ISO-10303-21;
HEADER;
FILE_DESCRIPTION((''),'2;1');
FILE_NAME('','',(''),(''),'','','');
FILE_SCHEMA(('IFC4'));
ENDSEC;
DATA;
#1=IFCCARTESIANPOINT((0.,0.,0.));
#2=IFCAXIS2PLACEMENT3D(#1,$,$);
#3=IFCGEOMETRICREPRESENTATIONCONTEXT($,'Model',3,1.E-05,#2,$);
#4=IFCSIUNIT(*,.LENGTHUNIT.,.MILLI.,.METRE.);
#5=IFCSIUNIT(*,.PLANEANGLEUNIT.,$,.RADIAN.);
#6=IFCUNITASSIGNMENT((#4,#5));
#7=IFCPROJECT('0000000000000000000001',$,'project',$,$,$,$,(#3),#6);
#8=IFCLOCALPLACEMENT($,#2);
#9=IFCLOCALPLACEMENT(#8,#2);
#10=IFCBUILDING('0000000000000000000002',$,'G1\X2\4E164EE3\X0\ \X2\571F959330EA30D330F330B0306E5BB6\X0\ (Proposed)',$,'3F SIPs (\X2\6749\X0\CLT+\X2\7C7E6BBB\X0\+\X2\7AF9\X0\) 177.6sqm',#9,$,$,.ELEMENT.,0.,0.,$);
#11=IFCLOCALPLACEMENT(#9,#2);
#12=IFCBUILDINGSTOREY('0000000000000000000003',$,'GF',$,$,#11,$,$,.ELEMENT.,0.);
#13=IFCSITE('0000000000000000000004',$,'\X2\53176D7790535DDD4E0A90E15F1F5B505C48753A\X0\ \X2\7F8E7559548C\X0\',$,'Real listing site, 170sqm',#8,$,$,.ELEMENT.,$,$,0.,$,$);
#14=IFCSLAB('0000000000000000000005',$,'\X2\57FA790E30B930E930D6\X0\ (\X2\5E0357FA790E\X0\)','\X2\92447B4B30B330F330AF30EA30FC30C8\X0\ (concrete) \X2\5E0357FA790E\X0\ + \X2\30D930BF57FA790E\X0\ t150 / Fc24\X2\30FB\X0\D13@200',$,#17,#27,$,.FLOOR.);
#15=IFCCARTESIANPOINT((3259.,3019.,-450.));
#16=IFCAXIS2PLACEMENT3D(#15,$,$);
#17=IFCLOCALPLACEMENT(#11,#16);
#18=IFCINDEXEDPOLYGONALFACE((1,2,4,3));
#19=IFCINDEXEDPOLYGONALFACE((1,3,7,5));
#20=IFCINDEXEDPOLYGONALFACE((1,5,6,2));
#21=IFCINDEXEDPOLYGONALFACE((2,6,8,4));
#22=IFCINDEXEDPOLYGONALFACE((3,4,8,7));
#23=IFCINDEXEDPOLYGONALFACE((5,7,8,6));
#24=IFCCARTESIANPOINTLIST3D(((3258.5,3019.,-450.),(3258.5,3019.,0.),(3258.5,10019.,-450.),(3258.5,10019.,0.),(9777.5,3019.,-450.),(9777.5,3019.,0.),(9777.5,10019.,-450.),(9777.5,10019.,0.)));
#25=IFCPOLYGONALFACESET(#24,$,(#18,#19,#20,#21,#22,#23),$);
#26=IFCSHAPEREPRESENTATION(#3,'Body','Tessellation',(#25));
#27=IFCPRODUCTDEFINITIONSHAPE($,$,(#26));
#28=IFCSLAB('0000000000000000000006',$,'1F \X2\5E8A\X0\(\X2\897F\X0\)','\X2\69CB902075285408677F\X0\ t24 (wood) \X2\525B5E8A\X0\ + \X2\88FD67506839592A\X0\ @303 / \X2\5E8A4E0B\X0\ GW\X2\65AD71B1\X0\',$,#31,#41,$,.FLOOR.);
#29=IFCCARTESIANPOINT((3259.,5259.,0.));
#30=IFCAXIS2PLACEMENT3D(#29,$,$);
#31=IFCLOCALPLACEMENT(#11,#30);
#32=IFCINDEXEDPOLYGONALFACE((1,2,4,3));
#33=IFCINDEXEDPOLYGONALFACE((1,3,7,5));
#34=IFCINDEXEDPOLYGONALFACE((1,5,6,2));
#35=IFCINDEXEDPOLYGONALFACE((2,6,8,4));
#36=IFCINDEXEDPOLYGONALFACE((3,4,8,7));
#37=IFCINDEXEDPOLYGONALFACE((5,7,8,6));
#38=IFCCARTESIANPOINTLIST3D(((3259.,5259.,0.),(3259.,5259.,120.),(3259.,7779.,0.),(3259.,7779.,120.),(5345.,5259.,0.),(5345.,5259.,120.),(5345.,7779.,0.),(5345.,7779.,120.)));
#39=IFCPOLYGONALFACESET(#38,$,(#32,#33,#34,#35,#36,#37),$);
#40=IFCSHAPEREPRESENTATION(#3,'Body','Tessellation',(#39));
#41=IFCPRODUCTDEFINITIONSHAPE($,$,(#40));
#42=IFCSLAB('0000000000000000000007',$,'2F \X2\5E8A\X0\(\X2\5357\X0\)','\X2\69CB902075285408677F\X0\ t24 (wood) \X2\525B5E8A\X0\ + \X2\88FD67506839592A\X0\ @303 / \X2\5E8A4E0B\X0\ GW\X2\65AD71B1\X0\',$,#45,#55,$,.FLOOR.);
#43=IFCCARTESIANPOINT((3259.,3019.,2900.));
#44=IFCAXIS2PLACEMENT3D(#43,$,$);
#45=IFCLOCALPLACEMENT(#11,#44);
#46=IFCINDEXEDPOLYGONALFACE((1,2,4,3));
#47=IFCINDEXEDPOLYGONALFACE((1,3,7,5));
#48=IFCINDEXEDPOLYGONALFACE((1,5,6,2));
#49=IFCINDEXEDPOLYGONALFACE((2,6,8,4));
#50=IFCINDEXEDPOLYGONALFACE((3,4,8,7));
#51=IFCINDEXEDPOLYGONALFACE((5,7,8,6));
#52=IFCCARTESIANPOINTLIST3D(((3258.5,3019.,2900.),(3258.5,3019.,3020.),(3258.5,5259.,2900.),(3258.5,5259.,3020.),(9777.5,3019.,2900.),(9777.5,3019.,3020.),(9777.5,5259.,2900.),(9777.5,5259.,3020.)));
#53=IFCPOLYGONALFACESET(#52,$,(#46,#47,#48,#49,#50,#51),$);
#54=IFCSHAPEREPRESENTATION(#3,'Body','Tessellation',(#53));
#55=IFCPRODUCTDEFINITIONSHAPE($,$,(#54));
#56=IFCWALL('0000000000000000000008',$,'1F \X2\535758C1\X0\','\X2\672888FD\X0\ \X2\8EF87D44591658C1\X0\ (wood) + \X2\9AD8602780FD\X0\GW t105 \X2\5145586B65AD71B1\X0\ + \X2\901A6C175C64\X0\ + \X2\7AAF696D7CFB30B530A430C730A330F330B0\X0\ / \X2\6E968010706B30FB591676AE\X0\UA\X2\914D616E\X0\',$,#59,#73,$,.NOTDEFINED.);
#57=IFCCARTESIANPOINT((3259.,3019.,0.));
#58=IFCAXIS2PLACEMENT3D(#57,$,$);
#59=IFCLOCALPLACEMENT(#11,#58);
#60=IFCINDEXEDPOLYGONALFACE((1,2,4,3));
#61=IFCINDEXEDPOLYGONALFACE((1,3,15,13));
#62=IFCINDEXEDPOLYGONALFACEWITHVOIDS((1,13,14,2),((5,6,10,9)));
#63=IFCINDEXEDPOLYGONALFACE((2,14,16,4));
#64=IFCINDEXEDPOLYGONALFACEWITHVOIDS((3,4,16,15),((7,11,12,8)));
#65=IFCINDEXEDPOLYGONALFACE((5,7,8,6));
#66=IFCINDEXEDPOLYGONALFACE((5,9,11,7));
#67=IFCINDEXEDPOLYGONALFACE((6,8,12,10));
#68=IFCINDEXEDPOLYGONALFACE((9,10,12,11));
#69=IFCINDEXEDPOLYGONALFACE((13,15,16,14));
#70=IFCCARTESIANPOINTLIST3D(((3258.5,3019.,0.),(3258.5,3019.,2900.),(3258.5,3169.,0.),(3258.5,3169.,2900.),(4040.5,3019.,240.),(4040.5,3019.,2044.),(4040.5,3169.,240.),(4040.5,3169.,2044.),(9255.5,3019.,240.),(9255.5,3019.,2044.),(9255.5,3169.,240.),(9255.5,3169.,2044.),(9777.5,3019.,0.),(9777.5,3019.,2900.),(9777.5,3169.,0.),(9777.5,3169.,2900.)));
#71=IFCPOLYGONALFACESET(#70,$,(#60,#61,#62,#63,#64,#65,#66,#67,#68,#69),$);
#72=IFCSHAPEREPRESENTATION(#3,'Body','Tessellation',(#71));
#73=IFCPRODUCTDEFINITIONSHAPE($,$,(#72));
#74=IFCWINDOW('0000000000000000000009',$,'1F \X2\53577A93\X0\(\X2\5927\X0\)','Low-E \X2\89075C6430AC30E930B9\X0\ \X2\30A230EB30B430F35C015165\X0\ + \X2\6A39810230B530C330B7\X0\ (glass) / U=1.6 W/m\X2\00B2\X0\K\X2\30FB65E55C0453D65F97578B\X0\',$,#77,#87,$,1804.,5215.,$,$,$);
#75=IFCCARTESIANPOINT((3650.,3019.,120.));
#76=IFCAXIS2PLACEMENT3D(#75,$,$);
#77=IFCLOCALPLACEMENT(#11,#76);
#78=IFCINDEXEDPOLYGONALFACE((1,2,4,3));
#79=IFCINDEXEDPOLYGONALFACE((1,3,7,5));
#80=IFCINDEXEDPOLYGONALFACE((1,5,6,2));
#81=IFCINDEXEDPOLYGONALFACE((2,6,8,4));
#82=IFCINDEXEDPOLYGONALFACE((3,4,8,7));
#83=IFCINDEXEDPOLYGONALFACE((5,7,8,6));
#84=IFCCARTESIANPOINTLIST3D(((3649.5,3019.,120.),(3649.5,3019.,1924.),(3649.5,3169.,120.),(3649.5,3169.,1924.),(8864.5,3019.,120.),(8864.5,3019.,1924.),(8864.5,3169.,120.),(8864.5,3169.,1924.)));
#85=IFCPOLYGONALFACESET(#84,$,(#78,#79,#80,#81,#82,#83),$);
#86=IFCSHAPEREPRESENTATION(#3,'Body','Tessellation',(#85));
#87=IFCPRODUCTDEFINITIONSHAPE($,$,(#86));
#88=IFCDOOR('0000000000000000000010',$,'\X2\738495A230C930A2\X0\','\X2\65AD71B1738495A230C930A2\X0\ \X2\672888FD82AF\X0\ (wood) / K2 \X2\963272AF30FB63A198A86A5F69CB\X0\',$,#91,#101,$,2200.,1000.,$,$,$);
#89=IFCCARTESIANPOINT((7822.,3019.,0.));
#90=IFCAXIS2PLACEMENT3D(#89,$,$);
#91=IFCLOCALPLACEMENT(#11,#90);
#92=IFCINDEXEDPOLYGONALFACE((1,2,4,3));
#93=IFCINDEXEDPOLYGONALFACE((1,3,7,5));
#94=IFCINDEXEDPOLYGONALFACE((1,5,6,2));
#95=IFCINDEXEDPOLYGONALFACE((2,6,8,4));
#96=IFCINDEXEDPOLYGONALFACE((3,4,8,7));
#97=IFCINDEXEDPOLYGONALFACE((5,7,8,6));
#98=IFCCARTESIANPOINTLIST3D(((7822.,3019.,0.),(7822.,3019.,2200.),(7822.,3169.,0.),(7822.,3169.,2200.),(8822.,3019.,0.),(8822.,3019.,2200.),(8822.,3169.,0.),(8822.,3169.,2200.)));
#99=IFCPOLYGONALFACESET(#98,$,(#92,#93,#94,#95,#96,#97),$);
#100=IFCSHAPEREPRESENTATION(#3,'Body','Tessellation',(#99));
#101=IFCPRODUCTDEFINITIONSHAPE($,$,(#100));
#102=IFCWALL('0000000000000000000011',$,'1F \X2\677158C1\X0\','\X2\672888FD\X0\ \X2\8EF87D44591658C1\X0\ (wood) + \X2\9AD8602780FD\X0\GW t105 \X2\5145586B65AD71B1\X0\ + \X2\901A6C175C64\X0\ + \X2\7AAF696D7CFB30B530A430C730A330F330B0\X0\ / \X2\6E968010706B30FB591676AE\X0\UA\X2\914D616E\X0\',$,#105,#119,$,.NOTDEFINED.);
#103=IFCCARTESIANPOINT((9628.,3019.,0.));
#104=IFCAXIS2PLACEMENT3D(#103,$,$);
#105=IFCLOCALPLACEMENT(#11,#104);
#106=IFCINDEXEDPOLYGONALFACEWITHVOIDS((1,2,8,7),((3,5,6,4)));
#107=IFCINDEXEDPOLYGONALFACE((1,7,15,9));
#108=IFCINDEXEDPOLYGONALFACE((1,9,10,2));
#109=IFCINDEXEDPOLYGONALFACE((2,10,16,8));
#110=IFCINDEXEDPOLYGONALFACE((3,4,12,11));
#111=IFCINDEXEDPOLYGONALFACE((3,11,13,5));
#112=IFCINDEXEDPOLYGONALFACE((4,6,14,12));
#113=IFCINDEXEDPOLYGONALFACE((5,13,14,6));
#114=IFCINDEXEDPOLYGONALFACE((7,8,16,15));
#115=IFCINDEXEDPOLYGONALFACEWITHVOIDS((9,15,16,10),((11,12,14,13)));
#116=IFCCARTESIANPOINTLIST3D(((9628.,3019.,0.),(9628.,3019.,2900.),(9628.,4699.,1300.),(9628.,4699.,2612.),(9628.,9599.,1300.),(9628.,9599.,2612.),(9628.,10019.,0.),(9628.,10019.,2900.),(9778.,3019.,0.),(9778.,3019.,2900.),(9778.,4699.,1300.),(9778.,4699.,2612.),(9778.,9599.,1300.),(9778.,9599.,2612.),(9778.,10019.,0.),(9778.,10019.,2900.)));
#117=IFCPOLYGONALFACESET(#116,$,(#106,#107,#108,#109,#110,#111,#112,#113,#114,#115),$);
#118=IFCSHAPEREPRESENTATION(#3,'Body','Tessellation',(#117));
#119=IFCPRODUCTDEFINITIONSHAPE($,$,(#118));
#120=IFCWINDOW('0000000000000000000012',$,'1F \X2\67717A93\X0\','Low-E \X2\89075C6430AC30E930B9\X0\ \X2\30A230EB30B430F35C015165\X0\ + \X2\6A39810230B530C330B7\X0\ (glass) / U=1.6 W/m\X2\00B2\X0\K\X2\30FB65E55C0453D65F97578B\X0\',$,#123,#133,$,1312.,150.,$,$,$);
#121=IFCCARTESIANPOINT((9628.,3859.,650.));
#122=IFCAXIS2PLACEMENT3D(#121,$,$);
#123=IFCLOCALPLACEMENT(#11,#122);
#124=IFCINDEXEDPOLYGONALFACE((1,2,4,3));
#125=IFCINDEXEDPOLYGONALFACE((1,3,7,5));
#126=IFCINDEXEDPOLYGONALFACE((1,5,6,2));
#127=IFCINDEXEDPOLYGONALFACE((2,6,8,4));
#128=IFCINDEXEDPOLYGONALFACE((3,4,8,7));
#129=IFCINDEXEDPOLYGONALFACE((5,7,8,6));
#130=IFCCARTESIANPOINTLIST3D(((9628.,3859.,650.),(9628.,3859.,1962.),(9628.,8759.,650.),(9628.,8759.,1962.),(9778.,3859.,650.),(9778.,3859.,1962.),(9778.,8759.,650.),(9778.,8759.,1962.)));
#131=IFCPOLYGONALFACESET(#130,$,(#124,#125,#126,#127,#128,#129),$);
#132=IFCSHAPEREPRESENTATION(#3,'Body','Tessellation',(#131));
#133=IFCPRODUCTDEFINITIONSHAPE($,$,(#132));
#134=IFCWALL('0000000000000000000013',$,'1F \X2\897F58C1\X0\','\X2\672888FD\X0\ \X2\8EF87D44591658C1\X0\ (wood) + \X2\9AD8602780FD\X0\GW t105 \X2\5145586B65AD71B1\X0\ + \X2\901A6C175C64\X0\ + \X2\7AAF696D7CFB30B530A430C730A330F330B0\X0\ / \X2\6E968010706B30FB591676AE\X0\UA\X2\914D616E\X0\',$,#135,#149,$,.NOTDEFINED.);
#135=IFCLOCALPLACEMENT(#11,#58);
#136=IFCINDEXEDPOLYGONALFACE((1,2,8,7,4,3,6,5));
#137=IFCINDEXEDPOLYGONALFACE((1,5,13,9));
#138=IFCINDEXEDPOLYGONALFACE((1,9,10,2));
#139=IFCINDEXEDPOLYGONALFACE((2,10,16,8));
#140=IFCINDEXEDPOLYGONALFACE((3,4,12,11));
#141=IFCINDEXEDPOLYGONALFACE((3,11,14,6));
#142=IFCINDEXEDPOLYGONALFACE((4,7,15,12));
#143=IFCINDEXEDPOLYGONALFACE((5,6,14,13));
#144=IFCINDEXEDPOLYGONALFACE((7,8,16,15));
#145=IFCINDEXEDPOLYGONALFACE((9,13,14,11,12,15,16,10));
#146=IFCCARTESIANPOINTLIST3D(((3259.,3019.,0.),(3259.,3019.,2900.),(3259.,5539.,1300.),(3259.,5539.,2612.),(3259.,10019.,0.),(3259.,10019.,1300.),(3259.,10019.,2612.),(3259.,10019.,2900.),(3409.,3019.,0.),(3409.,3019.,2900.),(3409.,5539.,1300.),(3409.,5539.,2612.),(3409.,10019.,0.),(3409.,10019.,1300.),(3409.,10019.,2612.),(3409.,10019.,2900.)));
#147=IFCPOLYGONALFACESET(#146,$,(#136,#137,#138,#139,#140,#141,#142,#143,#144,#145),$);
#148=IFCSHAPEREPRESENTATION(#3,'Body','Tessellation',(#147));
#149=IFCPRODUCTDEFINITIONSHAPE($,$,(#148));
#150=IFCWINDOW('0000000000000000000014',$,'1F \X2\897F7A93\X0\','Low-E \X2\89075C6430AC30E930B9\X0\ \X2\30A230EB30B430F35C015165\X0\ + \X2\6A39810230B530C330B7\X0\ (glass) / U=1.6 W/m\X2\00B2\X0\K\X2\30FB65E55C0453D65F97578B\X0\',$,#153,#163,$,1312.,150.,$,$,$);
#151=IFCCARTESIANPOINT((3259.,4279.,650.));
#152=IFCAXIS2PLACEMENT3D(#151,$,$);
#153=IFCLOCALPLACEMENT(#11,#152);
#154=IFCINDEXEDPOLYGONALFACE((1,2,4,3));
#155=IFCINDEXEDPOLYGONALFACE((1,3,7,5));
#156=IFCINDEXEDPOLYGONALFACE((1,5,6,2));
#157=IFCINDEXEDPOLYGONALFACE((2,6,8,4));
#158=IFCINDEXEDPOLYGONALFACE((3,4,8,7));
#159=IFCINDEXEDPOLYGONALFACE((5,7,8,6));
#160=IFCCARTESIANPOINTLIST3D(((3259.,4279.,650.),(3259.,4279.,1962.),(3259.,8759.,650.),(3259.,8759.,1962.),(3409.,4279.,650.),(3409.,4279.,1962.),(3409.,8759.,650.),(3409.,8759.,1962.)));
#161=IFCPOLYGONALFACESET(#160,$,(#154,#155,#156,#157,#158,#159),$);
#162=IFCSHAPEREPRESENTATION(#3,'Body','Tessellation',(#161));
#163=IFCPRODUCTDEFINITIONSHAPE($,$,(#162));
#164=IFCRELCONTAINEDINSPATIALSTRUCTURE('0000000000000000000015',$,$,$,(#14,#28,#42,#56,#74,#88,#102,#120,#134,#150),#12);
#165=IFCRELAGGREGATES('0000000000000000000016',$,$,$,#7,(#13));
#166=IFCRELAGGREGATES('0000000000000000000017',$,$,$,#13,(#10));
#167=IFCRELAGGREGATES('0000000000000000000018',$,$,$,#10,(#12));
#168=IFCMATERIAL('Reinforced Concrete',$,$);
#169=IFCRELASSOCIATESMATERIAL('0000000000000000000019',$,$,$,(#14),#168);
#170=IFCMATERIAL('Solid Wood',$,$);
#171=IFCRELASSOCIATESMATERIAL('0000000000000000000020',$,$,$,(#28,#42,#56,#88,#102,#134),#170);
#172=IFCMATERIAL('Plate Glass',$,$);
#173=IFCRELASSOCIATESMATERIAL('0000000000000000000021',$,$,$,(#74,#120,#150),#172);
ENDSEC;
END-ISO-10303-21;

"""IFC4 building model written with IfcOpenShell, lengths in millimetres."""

from ifc_helpers import new_model, si_unit, frame, frame_2d, origin, place, context, project, spatial, rectangle, extrude, material, element, fill, save


model = new_model("IFC4")

# Units and contexts
model_context = context("Model", 3, precision=1e-05, world=origin())
ifc_project = project(units=[si_unit("LENGTHUNIT", "METRE", prefix="MILLI"), si_unit("PLANEANGLEUNIT", "RADIAN")], contexts=[model_context])

# Site, building, storey
site_placement = place(None, origin())
site = spatial("IfcSite", under=ifc_project, at=site_placement, Name="北海道川上郡弟子屈町 美留和", ObjectType="Real listing site, 170sqm", CompositionType="ELEMENT", RefElevation=0.0)
building_placement = place(site_placement, origin())
building = spatial("IfcBuilding", under=site, at=building_placement, Name="G1世代 土間リビングの家 (Proposed)", ObjectType="3F SIPs (杉CLT+籾殻+竹) 177.6sqm", CompositionType="ELEMENT", ElevationOfRefHeight=0.0, ElevationOfTerrain=0.0)
storey_placement = place(building_placement, origin())
storey = spatial("IfcBuildingStorey", under=building, at=storey_placement, Name="GF", CompositionType="ELEMENT", Elevation=0.0)

# Slabs
ifc_material_1 = material(Name="Reinforced Concrete")
slab_1_placement = place(storey_placement, frame((3259.0, 3019.0, -450.0)))
element("IfcSlab", 1, at=slab_1_placement, inside=storey, material=ifc_material_1, Name="基礎スラブ (布基礎)", Description="鉄筋コンクリート (concrete) 布基礎 + ベタ基礎 t150 / Fc24・D13@200", PredefinedType="FLOOR", context=model_context, shape_type="SweptSolid", body=[
    extrude(rectangle(XDim=6519.0, YDim=7000.0, at=frame_2d((3259.0, 3500.0))), frame((3259.0, 3019.0, -450.0)), (0.0, 0.0, 1.0), 450.0),
])
ifc_material_2 = material(Name="Solid Wood")
slab_2_placement = place(storey_placement, frame((3259.0, 5259.0, 0.0)))
element("IfcSlab", 2, at=slab_2_placement, inside=storey, material=ifc_material_2, Name="1F 床(西)", Description="構造用合板 t24 (wood) 剛床 + 製材根太 @303 / 床下 GW断熱", PredefinedType="FLOOR", context=model_context, shape_type="SweptSolid", body=[
    extrude(rectangle(XDim=2086.0, YDim=2520.0, at=frame_2d((1043.0, 1260.0))), frame((3259.0, 5259.0, 0.0)), (0.0, 0.0, 1.0), 120.0),
])
slab_3_placement = place(storey_placement, frame((3259.0, 3019.0, 2900.0)))
element("IfcSlab", 3, at=slab_3_placement, inside=storey, material=ifc_material_2, Name="2F 床(南)", Description="構造用合板 t24 (wood) 剛床 + 製材根太 @303 / 床下 GW断熱", PredefinedType="FLOOR", context=model_context, shape_type="SweptSolid", body=[
    extrude(rectangle(XDim=6519.0, YDim=2240.0, at=frame_2d((3259.0, 1120.0))), frame((3259.0, 3019.0, 2900.0)), (0.0, 0.0, 1.0), 120.0),
])

# Wall, openings, window, door
wall_1_placement = place(storey_placement, frame((3259.0, 3019.0, 0.0)))
wall_1 = element("IfcWall", 4, at=wall_1_placement, inside=storey, material=ifc_material_2, Name="1F 南壁", Description="木製 軸組外壁 (wood) + 高性能GW t105 充填断熱 + 通気層 + 窯業系サイディング / 準耐火・外皮UA配慮", PredefinedType="NOTDEFINED", context=model_context, shape_type="SweptSolid", body=[
    extrude(rectangle(XDim=6519.0, YDim=150.0, at=frame_2d((3259.0, 75.0))), frame((3259.0, 3019.0, 0.0)), (0.0, 0.0, 1.0), 2900.0),
])
opening_1_placement = place(storey_placement, frame((3650.0, 3019.0, 120.0)))
opening_1 = element("IfcOpeningElement", 5, at=opening_1_placement, cuts=wall_1, PredefinedType="NOTDEFINED", context=model_context, shape_type="SweptSolid", body=[
    extrude(rectangle(XDim=5215.0, YDim=150.0, at=frame_2d((2607.0, 75.0))), frame((3650.0, 3019.0, 120.0)), (0.0, 0.0, 1.0), 1804.0),
])
opening_2_placement = place(storey_placement, frame((7822.0, 3019.0, 0.0)))
opening_2 = element("IfcOpeningElement", 6, at=opening_2_placement, cuts=wall_1, PredefinedType="NOTDEFINED", context=model_context, shape_type="SweptSolid", body=[
    extrude(rectangle(XDim=1000.0, YDim=150.0, at=frame_2d((500.0, 75.0))), frame((7822.0, 3019.0, 0.0)), (0.0, 0.0, 1.0), 2200.0),
])
ifc_material_3 = material(Name="Plate Glass")
window_1_placement = place(storey_placement, frame((3650.0, 3019.0, 120.0)))
window_1 = element("IfcWindow", 7, at=window_1_placement, inside=storey, material=ifc_material_3, Name="1F 南窓(大)", Description="Low-E 複層ガラス アルゴン封入 + 樹脂サッシ (glass) / U=1.6 W/m²K・日射取得型", OverallHeight=1804.0, OverallWidth=5215.0, context=model_context, shape_type="SweptSolid", body=[
    extrude(rectangle(XDim=5215.0, YDim=150.0, at=frame_2d((2607.0, 75.0))), frame((3650.0, 3019.0, 120.0)), (0.0, 0.0, 1.0), 1804.0),
])
fill(opening_1, window_1)
door_placement = place(storey_placement, frame((7822.0, 3019.0, 0.0)))
door = element("IfcDoor", 8, at=door_placement, inside=storey, material=ifc_material_2, Name="玄関ドア", Description="断熱玄関ドア 木製芯 (wood) / K2 防犯・採風機構", OverallHeight=2200.0, OverallWidth=1000.0, context=model_context, shape_type="SweptSolid", body=[
    extrude(rectangle(XDim=1000.0, YDim=150.0, at=frame_2d((500.0, 75.0))), frame((7822.0, 3019.0, 0.0)), (0.0, 0.0, 1.0), 2200.0),
])
fill(opening_2, door)

# Walls, openings, windows
wall_2_placement = place(storey_placement, frame((9628.0, 3019.0, 0.0)))
wall_2 = element("IfcWall", 9, at=wall_2_placement, inside=storey, material=ifc_material_2, Name="1F 東壁", Description="木製 軸組外壁 (wood) + 高性能GW t105 充填断熱 + 通気層 + 窯業系サイディング / 準耐火・外皮UA配慮", PredefinedType="NOTDEFINED", context=model_context, shape_type="SweptSolid", body=[
    extrude(rectangle(XDim=150.0, YDim=7000.0, at=frame_2d((75.0, 3500.0))), frame((9628.0, 3019.0, 0.0)), (0.0, 0.0, 1.0), 2900.0),
])
opening_3_placement = place(storey_placement, frame((9628.0, 3859.0, 650.0)))
opening_3 = element("IfcOpeningElement", 10, at=opening_3_placement, cuts=wall_2, PredefinedType="NOTDEFINED", context=model_context, shape_type="SweptSolid", body=[
    extrude(rectangle(XDim=150.0, YDim=4900.0, at=frame_2d((75.0, 2450.0))), frame((9628.0, 3859.0, 650.0)), (0.0, 0.0, 1.0), 1312.0),
])
window_2_placement = place(storey_placement, frame((9628.0, 3859.0, 650.0)))
window_2 = element("IfcWindow", 11, at=window_2_placement, inside=storey, material=ifc_material_3, Name="1F 東窓", Description="Low-E 複層ガラス アルゴン封入 + 樹脂サッシ (glass) / U=1.6 W/m²K・日射取得型", OverallHeight=1312.0, OverallWidth=150.0, context=model_context, shape_type="SweptSolid", body=[
    extrude(rectangle(XDim=150.0, YDim=4900.0, at=frame_2d((75.0, 2450.0))), frame((9628.0, 3859.0, 650.0)), (0.0, 0.0, 1.0), 1312.0),
])
fill(opening_3, window_2)
wall_3_placement = place(storey_placement, frame((3259.0, 3019.0, 0.0)))
wall_3 = element("IfcWall", 12, at=wall_3_placement, inside=storey, material=ifc_material_2, Name="1F 西壁", Description="木製 軸組外壁 (wood) + 高性能GW t105 充填断熱 + 通気層 + 窯業系サイディング / 準耐火・外皮UA配慮", PredefinedType="NOTDEFINED", context=model_context, shape_type="SweptSolid", body=[
    extrude(rectangle(XDim=150.0, YDim=7000.0, at=frame_2d((75.0, 3500.0))), frame((3259.0, 3019.0, 0.0)), (0.0, 0.0, 1.0), 2900.0),
])
opening_4_placement = place(storey_placement, frame((3259.0, 4279.0, 650.0)))
opening_4 = element("IfcOpeningElement", 13, at=opening_4_placement, cuts=wall_3, PredefinedType="NOTDEFINED", context=model_context, shape_type="SweptSolid", body=[
    extrude(rectangle(XDim=150.0, YDim=4480.0, at=frame_2d((75.0, 2240.0))), frame((3259.0, 4279.0, 650.0)), (0.0, 0.0, 1.0), 1312.0),
])
window_3_placement = place(storey_placement, frame((3259.0, 4279.0, 650.0)))
window_3 = element("IfcWindow", 14, at=window_3_placement, inside=storey, material=ifc_material_3, Name="1F 西窓", Description="Low-E 複層ガラス アルゴン封入 + 樹脂サッシ (glass) / U=1.6 W/m²K・日射取得型", OverallHeight=1312.0, OverallWidth=150.0, context=model_context, shape_type="SweptSolid", body=[
    extrude(rectangle(XDim=150.0, YDim=4480.0, at=frame_2d((75.0, 2240.0))), frame((3259.0, 4279.0, 650.0)), (0.0, 0.0, 1.0), 1312.0),
])
fill(opening_4, window_3)

save(model, "model.ifc")
